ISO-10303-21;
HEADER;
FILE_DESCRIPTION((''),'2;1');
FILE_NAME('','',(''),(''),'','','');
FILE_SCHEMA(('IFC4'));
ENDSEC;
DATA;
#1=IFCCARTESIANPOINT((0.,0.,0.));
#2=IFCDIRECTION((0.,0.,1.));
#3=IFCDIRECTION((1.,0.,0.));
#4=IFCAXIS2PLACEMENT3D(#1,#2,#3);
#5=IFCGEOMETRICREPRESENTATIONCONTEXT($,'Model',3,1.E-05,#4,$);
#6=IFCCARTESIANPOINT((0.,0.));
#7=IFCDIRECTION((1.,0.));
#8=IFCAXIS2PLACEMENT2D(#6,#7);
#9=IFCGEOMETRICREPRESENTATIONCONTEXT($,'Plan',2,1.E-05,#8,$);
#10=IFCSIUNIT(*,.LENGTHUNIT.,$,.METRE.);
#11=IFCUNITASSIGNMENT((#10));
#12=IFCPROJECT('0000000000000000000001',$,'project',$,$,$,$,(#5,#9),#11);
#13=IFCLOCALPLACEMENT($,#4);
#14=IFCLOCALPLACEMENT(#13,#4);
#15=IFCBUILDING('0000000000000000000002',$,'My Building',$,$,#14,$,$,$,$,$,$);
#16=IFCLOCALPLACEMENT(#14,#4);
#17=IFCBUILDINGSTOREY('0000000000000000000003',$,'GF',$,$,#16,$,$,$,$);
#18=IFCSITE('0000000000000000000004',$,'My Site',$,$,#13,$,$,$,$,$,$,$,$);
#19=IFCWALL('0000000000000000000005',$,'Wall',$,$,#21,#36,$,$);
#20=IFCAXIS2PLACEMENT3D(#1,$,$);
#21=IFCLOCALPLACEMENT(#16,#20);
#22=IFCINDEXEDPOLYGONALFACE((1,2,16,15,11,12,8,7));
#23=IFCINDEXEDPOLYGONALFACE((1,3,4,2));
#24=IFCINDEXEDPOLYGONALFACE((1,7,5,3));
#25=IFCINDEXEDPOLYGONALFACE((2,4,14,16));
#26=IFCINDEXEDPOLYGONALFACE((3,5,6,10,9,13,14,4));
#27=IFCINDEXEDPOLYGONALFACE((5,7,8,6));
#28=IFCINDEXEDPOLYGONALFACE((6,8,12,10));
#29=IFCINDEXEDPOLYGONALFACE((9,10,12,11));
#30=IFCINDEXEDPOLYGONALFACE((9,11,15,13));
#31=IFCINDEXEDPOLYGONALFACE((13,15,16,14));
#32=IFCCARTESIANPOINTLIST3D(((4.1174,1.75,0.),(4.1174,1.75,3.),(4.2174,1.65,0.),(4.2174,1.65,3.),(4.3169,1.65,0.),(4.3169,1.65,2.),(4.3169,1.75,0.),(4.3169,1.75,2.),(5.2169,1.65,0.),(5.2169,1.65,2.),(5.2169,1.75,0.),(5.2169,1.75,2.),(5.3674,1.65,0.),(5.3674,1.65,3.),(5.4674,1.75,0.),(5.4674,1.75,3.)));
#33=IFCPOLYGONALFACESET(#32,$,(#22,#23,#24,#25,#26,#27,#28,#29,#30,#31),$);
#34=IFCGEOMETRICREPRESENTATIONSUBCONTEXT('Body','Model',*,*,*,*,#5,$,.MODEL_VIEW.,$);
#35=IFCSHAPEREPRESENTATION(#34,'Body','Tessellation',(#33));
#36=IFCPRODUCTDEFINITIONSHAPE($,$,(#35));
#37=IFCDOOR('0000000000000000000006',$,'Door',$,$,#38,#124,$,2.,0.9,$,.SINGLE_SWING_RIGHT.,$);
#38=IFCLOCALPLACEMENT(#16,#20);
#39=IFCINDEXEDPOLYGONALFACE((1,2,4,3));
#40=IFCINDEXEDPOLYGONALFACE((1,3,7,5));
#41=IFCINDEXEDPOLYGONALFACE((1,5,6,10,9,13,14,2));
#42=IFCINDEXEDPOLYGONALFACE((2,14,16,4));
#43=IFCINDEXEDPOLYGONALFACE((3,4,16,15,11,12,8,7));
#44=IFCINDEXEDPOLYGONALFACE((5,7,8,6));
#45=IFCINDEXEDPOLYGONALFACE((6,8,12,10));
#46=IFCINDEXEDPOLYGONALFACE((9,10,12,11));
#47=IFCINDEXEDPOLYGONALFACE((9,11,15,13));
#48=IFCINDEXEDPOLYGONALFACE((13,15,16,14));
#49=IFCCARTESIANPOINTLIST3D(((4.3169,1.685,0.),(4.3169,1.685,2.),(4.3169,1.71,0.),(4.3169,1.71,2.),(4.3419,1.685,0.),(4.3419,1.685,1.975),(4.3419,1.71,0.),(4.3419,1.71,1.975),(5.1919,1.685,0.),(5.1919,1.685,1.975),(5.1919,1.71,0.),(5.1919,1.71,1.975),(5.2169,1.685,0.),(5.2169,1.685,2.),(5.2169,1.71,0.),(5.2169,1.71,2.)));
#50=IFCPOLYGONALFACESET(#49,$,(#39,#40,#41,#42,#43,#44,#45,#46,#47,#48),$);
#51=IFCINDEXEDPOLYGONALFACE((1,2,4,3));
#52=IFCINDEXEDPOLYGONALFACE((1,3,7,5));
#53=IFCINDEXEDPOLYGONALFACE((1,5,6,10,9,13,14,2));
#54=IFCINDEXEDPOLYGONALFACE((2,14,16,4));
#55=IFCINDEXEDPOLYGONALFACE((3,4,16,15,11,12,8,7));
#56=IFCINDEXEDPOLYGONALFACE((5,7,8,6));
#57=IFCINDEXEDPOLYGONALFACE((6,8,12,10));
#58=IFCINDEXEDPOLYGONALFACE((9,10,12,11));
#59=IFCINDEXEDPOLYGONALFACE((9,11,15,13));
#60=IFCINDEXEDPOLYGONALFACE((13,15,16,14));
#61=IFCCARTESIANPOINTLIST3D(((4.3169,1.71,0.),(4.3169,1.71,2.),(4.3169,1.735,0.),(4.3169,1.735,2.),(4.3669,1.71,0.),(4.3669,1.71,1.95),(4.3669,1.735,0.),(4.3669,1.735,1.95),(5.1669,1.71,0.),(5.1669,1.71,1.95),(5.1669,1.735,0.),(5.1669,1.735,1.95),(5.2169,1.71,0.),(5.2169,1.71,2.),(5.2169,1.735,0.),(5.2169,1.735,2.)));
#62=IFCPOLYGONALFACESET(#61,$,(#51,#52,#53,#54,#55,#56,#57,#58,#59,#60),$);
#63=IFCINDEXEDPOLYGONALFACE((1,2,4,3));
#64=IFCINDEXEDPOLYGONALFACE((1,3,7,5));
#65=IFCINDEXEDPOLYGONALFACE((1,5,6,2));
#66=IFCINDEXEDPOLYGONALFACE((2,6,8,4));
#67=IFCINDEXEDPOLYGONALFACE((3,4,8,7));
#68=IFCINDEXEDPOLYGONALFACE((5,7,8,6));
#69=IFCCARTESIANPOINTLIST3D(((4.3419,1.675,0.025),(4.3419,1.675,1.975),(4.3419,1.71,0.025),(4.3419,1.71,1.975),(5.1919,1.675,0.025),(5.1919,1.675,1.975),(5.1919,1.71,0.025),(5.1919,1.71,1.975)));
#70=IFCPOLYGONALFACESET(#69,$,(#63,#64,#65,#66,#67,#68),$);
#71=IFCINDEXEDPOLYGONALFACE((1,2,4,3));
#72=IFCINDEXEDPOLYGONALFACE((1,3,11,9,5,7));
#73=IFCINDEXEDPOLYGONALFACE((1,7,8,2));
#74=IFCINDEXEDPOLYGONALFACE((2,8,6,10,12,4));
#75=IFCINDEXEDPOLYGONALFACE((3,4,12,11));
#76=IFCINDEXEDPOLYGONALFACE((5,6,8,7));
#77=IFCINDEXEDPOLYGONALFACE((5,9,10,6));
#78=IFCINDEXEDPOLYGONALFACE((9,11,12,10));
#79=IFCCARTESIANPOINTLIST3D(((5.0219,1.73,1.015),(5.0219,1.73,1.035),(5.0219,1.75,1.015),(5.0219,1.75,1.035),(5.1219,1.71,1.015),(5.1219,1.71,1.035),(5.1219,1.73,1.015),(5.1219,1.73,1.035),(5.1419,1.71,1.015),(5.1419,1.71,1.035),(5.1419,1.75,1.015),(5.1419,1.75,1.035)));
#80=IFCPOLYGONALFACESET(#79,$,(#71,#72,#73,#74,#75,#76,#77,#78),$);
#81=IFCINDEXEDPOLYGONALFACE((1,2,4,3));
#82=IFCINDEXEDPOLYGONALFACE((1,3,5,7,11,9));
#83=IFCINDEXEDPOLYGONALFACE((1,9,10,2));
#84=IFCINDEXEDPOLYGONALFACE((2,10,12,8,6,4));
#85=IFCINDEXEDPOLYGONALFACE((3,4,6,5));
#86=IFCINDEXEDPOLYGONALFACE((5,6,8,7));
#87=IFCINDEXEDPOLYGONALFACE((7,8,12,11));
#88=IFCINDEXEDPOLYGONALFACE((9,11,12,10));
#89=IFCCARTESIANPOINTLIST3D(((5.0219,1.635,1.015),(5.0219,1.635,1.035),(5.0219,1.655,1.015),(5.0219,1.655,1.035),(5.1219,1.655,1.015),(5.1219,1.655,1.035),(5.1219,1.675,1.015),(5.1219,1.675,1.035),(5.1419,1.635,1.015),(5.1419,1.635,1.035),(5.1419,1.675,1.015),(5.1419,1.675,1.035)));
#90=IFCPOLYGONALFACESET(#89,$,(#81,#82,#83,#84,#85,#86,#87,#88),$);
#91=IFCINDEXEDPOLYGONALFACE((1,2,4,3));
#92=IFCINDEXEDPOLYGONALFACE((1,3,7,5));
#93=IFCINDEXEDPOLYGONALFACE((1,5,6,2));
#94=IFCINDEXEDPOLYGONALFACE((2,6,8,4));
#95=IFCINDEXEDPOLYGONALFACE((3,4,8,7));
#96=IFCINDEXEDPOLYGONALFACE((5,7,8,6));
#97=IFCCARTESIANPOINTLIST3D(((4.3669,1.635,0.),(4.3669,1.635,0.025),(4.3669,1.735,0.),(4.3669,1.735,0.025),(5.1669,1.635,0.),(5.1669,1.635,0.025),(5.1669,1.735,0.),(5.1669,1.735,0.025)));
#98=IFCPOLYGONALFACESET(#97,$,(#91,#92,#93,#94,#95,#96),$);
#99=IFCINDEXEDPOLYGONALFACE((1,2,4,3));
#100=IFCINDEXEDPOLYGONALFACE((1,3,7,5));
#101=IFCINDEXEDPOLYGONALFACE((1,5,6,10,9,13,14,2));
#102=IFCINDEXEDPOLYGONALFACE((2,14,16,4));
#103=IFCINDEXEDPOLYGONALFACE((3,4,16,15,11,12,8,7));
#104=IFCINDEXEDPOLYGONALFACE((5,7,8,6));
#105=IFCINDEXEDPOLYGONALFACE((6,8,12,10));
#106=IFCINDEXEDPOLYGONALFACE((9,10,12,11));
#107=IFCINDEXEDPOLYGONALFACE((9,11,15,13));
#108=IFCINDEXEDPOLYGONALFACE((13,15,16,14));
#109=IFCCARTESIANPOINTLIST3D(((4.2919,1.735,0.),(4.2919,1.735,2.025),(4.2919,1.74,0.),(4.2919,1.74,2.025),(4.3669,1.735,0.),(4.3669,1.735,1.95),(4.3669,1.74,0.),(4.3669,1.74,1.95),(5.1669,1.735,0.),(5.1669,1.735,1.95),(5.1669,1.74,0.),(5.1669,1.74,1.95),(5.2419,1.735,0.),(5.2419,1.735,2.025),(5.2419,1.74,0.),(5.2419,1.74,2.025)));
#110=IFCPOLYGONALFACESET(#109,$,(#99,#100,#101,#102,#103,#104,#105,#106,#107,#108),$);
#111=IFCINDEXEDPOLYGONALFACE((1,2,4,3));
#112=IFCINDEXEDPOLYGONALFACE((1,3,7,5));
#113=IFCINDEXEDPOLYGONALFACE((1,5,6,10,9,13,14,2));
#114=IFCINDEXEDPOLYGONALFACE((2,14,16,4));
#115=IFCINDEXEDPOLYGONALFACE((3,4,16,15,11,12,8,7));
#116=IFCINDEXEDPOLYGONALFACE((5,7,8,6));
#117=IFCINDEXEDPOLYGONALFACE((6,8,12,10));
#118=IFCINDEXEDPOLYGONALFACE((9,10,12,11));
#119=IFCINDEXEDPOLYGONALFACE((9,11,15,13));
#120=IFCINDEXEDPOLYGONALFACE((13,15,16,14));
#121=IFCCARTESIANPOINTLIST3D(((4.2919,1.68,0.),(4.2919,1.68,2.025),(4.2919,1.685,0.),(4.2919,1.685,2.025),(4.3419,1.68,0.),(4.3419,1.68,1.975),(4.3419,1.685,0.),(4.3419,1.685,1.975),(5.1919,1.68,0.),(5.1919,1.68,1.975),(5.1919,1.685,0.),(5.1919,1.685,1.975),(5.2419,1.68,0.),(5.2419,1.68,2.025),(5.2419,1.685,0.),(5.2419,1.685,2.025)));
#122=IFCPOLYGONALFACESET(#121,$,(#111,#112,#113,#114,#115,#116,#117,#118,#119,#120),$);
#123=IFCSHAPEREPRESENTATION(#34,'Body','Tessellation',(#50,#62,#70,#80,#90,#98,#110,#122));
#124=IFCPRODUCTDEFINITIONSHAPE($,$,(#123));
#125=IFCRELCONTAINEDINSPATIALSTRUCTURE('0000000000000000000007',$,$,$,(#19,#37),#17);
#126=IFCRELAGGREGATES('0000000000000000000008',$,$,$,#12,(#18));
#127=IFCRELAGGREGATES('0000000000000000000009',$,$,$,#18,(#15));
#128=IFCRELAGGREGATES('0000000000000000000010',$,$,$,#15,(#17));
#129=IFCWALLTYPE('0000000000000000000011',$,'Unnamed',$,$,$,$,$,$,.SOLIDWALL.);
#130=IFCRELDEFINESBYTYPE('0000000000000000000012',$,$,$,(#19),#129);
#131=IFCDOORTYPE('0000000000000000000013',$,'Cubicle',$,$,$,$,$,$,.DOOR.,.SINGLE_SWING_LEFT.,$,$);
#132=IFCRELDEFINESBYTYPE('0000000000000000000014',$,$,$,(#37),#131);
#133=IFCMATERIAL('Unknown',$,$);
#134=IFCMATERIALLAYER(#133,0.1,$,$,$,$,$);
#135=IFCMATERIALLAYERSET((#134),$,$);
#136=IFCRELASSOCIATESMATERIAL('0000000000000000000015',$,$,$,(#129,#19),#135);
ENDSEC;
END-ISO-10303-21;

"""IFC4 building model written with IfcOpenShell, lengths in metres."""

from ifc_helpers import new_model, entity, si_unit, frame, origin_with_axes, origin_2d_with_axis, place, context, subcontext, project, spatial, line, indexed_curve, outline, extrude, shape, source, transform, mapped, material, layer, layer_set, layer_usage, type_object, type_shapes, element, fill, save


model = new_model("IFC4")

# Units and contexts
model_context = context("Model", 3, precision=1e-05, world=origin_with_axes())
plan_context = context("Plan", 2, precision=1e-05, world=origin_2d_with_axis())
body_context_1 = subcontext(model_context, "Body", "Model", "MODEL_VIEW")
body_context_2 = subcontext(plan_context, "Body", "Plan", "PLAN_VIEW")
ifc_project = project(units=[si_unit("LENGTHUNIT", "METRE")], contexts=[model_context, plan_context])

# Site, building, storey
site_placement = place(None, origin_with_axes())
site = spatial("IfcSite", under=ifc_project, at=site_placement, Name="My Site")
building_placement = place(site_placement, origin_with_axes())
building = spatial("IfcBuilding", under=site, at=building_placement, Name="My Building")
storey_placement = place(building_placement, origin_with_axes())
storey = spatial("IfcBuildingStorey", under=building, at=storey_placement, Name="GF")

# Shared definitions
ifc_material = material(Name="Unknown")

# Shared definitions
ifc_layer_1 = layer(ifc_material, 0.1)
ifc_layer_set_1 = layer_set([ifc_layer_1])
wall_type = type_object("IfcWallType", Name="Unnamed", PredefinedType="SOLIDWALL", material=ifc_layer_set_1)

# Wall, opening, door
shared_shape_1 = source(origin_with_axes(), body_context_1, "Body", "SweptSolid", [
    extrude(outline(indexed_curve([(0.0, 0.0), (0.9, 0.0), (0.9, 2.0), (0.0, 2.0)], segments=[line(1, 2, 3, 4, 1)])), frame((0.0, -0.6, 0.0), z_axis=(0.0, -1.0, 0.0), x_axis=(1.0, 0.0, 0.0)), (0.0, 0.0, -1.0), 1.2),
])
door_type = type_object("IfcDoorType", Name="Cubicle", OperationType="SINGLE_SWING_LEFT", PredefinedType="DOOR")
shared_shape_2 = source(origin_with_axes(), body_context_1, "Body", "SweptSolid", [
    extrude(outline(indexed_curve([(0.0, 0.0), (0.0, 2.0), (0.9, 2.0), (0.9, 0.0), (0.875, 0.0), (0.875, 1.975), (0.025, 1.975), (0.025, 0.0)], segments=[line(1, 2, 3, 4, 5, 6, 7, 8, 1)])), frame((0.0, 0.025, 0.0), z_axis=(0.0, -1.0, 0.0), x_axis=(1.0, 0.0, 0.0)), (0.0, 0.0, -1.0), 0.025),
    extrude(outline(indexed_curve([(0.0, 0.0), (0.0, 2.0), (0.9, 2.0), (0.9, 0.0), (0.85, 0.0), (0.85, 1.95), (0.05, 1.95), (0.05, 0.0)], segments=[line(1, 2, 3, 4, 5, 6, 7, 8, 1)])), frame((0.0, 0.0, 0.0), z_axis=(0.0, -1.0, 0.0), x_axis=(1.0, 0.0, 0.0)), (0.0, 0.0, -1.0), 0.025),
    extrude(outline(indexed_curve([(0.0, 0.0), (0.85, 0.0), (0.85, 0.035), (0.0, 0.035)], segments=[line(1, 2, 3, 4, 1)])), frame((0.025, 0.025, 0.025), z_axis=(0.0, 0.0, 1.0), x_axis=(1.0, 0.0, 0.0)), (0.0, 0.0, 1.0), 1.95),
    extrude(outline(indexed_curve([(0.0, 0.0), (0.0, -0.04), (0.12, -0.04), (0.12, -0.02), (0.02, -0.02), (0.02, 0.0)], segments=[line(1, 2, 3, 4, 5, 6, 1)])), frame((0.075, 0.025, 1.015), z_axis=(0.0, 0.0, 1.0), x_axis=(1.0, 0.0, 0.0)), (0.0, 0.0, 1.0), 0.02),
    extrude(outline(indexed_curve([(0.0, 0.0), (0.0, 0.04), (0.12, 0.04), (0.12, 0.02), (0.02, 0.02), (0.02, 0.0)], segments=[line(1, 2, 3, 4, 5, 6, 1)])), frame((0.075, 0.06, 1.015), z_axis=(0.0, 0.0, 1.0), x_axis=(1.0, 0.0, 0.0)), (0.0, 0.0, 1.0), 0.02),
    extrude(outline(indexed_curve([(0.0, 0.0), (0.8, 0.0), (0.8, 0.1), (0.0, 0.1)], segments=[line(1, 2, 3, 4, 1)])), frame((0.05, 0.0, 0.0), z_axis=(0.0, 0.0, 1.0), x_axis=(1.0, 0.0, 0.0)), (0.0, 0.0, 1.0), 0.025),
    extrude(outline(indexed_curve([(0.0, 0.0), (0.0, 2.025), (0.95, 2.025), (0.95, 0.0), (0.875, 0.0), (0.875, 1.95), (0.075, 1.95), (0.075, 0.0)], segments=[line(1, 2, 3, 4, 5, 6, 7, 8, 1)])), frame((-0.025, -0.005, 0.0), z_axis=(0.0, -1.0, 0.0), x_axis=(1.0, 0.0, 0.0)), (0.0, 0.0, -1.0), 0.005),
    extrude(outline(indexed_curve([(0.0, 0.0), (0.0, 2.025), (0.95, 2.025), (0.95, 0.0), (0.9, 0.0), (0.9, 1.975), (0.05, 1.975), (0.05, 0.0)], segments=[line(1, 2, 3, 4, 5, 6, 7, 8, 1)])), frame((-0.025, 0.05, 0.0), z_axis=(0.0, -1.0, 0.0), x_axis=(1.0, 0.0, 0.0)), (0.0, 0.0, -1.0), 0.005),
])
shared_shape_3 = source(origin_with_axes(), body_context_2, "Body", "Curve2D", [
    entity("IfcIndexedPolyCurve", entity("IfcCartesianPointList2D", [[0.0, 0.0], [0.0, 0.05], [0.025, 0.05], [0.025, 0.025], [0.05, 0.025], [0.05, 0.0]]), [entity("IfcLineIndex", [1, 2, 3, 4, 5, 6, 1])]),
    entity("IfcIndexedPolyCurve", entity("IfcCartesianPointList2D", [[0.9, 0.0], [0.9, 0.05], [0.875, 0.05], [0.875, 0.025], [0.85, 0.025], [0.85, 0.0]]), [entity("IfcLineIndex", [1, 2, 3, 4, 5, 6, 1])]),
    entity("IfcTrimmedCurve", entity("IfcEllipse", entity("IfcAxis2Placement2D", entity("IfcCartesianPoint", [0.84, 0.05]), entity("IfcDirection", [1.0, 0.0])), 0.815, 0.85), [entity("IfcCartesianPoint", [0.84, 0.9])], [entity("IfcCartesianPoint", [0.025, 0.05])], True, "CARTESIAN"),
    entity("IfcIndexedPolyCurve", entity("IfcCartesianPointList2D", [[0.875, 0.05], [0.84, 0.05], [0.84, 0.9], [0.875, 0.9]]), [entity("IfcLineIndex", [1, 2, 3, 4, 1])]),
])
type_shapes(door_type, [shared_shape_2, shared_shape_3])
ifc_layer_usage_1 = layer_usage(ifc_layer_set_1, "AXIS2", "POSITIVE", 0.0)
wall_1_placement = place(storey_placement, frame((5.4674, 1.75, 0.0), z_axis=(0.0, 0.0, 1.0), x_axis=(-1.0, 0.0, 0.0)))
wall_1 = element("IfcWall", 1, at=wall_1_placement, inside=storey, type_object=wall_type, material=ifc_layer_usage_1, Name="Wall", context=body_context_1, shape_type="SweptSolid", body=[
    extrude(outline(indexed_curve([(0.0, 0.0), (0.1, 0.1), (1.25, 0.1), (1.35, 0.0)], segments=[line(1, 2, 3, 4, 1)])), origin_with_axes(), (0.0, 0.0, 1.0), 3.0),
])
opening_1_placement = place(wall_1_placement, frame((0.2506, 0.015, 0.0), z_axis=(0.0, 0.0, 1.0), x_axis=(1.0, 0.0, 0.0)))
opening_1 = element("IfcOpeningElement", 2, at=opening_1_placement, cuts=wall_1, PredefinedType="OPENING", context=body_context_1, shape_type="MappedRepresentation", body=[
    mapped(shared_shape_1, transform((0.0, 0.0, 0.0), x_axis=(1.0, 0.0, 0.0), y_axis=(0.0, 1.0, 0.0), z_axis=(0.0, 0.0, 1.0), scale=1.0)),
])
door_1_placement = place(opening_1_placement, frame((0.0, 0.0, 0.0), z_axis=(0.0, 0.0, 1.0), x_axis=(1.0, 0.0, 0.0)))
door_1 = element("IfcDoor", 3, at=door_1_placement, inside=storey, type_object=door_type, Name="Door", OperationType="SINGLE_SWING_RIGHT", OverallHeight=2.0, OverallWidth=0.9, shapes=[
    shape(body_context_1, "Body", "MappedRepresentation", [mapped(shared_shape_2, transform((0.0, 0.0, 0.0), x_axis=(1.0, 0.0, 0.0), y_axis=(0.0, 1.0, 0.0), z_axis=(0.0, 0.0, 1.0), scale=1.0))]),
    shape(body_context_2, "Body", "MappedRepresentation", [mapped(shared_shape_3, transform((0.0, 0.0, 0.0), x_axis=(1.0, 0.0, 0.0), y_axis=(0.0, 1.0, 0.0), z_axis=(0.0, 0.0, 1.0), scale=1.0))]),
])
fill(opening_1, door_1)

save(model, "model.ifc")
